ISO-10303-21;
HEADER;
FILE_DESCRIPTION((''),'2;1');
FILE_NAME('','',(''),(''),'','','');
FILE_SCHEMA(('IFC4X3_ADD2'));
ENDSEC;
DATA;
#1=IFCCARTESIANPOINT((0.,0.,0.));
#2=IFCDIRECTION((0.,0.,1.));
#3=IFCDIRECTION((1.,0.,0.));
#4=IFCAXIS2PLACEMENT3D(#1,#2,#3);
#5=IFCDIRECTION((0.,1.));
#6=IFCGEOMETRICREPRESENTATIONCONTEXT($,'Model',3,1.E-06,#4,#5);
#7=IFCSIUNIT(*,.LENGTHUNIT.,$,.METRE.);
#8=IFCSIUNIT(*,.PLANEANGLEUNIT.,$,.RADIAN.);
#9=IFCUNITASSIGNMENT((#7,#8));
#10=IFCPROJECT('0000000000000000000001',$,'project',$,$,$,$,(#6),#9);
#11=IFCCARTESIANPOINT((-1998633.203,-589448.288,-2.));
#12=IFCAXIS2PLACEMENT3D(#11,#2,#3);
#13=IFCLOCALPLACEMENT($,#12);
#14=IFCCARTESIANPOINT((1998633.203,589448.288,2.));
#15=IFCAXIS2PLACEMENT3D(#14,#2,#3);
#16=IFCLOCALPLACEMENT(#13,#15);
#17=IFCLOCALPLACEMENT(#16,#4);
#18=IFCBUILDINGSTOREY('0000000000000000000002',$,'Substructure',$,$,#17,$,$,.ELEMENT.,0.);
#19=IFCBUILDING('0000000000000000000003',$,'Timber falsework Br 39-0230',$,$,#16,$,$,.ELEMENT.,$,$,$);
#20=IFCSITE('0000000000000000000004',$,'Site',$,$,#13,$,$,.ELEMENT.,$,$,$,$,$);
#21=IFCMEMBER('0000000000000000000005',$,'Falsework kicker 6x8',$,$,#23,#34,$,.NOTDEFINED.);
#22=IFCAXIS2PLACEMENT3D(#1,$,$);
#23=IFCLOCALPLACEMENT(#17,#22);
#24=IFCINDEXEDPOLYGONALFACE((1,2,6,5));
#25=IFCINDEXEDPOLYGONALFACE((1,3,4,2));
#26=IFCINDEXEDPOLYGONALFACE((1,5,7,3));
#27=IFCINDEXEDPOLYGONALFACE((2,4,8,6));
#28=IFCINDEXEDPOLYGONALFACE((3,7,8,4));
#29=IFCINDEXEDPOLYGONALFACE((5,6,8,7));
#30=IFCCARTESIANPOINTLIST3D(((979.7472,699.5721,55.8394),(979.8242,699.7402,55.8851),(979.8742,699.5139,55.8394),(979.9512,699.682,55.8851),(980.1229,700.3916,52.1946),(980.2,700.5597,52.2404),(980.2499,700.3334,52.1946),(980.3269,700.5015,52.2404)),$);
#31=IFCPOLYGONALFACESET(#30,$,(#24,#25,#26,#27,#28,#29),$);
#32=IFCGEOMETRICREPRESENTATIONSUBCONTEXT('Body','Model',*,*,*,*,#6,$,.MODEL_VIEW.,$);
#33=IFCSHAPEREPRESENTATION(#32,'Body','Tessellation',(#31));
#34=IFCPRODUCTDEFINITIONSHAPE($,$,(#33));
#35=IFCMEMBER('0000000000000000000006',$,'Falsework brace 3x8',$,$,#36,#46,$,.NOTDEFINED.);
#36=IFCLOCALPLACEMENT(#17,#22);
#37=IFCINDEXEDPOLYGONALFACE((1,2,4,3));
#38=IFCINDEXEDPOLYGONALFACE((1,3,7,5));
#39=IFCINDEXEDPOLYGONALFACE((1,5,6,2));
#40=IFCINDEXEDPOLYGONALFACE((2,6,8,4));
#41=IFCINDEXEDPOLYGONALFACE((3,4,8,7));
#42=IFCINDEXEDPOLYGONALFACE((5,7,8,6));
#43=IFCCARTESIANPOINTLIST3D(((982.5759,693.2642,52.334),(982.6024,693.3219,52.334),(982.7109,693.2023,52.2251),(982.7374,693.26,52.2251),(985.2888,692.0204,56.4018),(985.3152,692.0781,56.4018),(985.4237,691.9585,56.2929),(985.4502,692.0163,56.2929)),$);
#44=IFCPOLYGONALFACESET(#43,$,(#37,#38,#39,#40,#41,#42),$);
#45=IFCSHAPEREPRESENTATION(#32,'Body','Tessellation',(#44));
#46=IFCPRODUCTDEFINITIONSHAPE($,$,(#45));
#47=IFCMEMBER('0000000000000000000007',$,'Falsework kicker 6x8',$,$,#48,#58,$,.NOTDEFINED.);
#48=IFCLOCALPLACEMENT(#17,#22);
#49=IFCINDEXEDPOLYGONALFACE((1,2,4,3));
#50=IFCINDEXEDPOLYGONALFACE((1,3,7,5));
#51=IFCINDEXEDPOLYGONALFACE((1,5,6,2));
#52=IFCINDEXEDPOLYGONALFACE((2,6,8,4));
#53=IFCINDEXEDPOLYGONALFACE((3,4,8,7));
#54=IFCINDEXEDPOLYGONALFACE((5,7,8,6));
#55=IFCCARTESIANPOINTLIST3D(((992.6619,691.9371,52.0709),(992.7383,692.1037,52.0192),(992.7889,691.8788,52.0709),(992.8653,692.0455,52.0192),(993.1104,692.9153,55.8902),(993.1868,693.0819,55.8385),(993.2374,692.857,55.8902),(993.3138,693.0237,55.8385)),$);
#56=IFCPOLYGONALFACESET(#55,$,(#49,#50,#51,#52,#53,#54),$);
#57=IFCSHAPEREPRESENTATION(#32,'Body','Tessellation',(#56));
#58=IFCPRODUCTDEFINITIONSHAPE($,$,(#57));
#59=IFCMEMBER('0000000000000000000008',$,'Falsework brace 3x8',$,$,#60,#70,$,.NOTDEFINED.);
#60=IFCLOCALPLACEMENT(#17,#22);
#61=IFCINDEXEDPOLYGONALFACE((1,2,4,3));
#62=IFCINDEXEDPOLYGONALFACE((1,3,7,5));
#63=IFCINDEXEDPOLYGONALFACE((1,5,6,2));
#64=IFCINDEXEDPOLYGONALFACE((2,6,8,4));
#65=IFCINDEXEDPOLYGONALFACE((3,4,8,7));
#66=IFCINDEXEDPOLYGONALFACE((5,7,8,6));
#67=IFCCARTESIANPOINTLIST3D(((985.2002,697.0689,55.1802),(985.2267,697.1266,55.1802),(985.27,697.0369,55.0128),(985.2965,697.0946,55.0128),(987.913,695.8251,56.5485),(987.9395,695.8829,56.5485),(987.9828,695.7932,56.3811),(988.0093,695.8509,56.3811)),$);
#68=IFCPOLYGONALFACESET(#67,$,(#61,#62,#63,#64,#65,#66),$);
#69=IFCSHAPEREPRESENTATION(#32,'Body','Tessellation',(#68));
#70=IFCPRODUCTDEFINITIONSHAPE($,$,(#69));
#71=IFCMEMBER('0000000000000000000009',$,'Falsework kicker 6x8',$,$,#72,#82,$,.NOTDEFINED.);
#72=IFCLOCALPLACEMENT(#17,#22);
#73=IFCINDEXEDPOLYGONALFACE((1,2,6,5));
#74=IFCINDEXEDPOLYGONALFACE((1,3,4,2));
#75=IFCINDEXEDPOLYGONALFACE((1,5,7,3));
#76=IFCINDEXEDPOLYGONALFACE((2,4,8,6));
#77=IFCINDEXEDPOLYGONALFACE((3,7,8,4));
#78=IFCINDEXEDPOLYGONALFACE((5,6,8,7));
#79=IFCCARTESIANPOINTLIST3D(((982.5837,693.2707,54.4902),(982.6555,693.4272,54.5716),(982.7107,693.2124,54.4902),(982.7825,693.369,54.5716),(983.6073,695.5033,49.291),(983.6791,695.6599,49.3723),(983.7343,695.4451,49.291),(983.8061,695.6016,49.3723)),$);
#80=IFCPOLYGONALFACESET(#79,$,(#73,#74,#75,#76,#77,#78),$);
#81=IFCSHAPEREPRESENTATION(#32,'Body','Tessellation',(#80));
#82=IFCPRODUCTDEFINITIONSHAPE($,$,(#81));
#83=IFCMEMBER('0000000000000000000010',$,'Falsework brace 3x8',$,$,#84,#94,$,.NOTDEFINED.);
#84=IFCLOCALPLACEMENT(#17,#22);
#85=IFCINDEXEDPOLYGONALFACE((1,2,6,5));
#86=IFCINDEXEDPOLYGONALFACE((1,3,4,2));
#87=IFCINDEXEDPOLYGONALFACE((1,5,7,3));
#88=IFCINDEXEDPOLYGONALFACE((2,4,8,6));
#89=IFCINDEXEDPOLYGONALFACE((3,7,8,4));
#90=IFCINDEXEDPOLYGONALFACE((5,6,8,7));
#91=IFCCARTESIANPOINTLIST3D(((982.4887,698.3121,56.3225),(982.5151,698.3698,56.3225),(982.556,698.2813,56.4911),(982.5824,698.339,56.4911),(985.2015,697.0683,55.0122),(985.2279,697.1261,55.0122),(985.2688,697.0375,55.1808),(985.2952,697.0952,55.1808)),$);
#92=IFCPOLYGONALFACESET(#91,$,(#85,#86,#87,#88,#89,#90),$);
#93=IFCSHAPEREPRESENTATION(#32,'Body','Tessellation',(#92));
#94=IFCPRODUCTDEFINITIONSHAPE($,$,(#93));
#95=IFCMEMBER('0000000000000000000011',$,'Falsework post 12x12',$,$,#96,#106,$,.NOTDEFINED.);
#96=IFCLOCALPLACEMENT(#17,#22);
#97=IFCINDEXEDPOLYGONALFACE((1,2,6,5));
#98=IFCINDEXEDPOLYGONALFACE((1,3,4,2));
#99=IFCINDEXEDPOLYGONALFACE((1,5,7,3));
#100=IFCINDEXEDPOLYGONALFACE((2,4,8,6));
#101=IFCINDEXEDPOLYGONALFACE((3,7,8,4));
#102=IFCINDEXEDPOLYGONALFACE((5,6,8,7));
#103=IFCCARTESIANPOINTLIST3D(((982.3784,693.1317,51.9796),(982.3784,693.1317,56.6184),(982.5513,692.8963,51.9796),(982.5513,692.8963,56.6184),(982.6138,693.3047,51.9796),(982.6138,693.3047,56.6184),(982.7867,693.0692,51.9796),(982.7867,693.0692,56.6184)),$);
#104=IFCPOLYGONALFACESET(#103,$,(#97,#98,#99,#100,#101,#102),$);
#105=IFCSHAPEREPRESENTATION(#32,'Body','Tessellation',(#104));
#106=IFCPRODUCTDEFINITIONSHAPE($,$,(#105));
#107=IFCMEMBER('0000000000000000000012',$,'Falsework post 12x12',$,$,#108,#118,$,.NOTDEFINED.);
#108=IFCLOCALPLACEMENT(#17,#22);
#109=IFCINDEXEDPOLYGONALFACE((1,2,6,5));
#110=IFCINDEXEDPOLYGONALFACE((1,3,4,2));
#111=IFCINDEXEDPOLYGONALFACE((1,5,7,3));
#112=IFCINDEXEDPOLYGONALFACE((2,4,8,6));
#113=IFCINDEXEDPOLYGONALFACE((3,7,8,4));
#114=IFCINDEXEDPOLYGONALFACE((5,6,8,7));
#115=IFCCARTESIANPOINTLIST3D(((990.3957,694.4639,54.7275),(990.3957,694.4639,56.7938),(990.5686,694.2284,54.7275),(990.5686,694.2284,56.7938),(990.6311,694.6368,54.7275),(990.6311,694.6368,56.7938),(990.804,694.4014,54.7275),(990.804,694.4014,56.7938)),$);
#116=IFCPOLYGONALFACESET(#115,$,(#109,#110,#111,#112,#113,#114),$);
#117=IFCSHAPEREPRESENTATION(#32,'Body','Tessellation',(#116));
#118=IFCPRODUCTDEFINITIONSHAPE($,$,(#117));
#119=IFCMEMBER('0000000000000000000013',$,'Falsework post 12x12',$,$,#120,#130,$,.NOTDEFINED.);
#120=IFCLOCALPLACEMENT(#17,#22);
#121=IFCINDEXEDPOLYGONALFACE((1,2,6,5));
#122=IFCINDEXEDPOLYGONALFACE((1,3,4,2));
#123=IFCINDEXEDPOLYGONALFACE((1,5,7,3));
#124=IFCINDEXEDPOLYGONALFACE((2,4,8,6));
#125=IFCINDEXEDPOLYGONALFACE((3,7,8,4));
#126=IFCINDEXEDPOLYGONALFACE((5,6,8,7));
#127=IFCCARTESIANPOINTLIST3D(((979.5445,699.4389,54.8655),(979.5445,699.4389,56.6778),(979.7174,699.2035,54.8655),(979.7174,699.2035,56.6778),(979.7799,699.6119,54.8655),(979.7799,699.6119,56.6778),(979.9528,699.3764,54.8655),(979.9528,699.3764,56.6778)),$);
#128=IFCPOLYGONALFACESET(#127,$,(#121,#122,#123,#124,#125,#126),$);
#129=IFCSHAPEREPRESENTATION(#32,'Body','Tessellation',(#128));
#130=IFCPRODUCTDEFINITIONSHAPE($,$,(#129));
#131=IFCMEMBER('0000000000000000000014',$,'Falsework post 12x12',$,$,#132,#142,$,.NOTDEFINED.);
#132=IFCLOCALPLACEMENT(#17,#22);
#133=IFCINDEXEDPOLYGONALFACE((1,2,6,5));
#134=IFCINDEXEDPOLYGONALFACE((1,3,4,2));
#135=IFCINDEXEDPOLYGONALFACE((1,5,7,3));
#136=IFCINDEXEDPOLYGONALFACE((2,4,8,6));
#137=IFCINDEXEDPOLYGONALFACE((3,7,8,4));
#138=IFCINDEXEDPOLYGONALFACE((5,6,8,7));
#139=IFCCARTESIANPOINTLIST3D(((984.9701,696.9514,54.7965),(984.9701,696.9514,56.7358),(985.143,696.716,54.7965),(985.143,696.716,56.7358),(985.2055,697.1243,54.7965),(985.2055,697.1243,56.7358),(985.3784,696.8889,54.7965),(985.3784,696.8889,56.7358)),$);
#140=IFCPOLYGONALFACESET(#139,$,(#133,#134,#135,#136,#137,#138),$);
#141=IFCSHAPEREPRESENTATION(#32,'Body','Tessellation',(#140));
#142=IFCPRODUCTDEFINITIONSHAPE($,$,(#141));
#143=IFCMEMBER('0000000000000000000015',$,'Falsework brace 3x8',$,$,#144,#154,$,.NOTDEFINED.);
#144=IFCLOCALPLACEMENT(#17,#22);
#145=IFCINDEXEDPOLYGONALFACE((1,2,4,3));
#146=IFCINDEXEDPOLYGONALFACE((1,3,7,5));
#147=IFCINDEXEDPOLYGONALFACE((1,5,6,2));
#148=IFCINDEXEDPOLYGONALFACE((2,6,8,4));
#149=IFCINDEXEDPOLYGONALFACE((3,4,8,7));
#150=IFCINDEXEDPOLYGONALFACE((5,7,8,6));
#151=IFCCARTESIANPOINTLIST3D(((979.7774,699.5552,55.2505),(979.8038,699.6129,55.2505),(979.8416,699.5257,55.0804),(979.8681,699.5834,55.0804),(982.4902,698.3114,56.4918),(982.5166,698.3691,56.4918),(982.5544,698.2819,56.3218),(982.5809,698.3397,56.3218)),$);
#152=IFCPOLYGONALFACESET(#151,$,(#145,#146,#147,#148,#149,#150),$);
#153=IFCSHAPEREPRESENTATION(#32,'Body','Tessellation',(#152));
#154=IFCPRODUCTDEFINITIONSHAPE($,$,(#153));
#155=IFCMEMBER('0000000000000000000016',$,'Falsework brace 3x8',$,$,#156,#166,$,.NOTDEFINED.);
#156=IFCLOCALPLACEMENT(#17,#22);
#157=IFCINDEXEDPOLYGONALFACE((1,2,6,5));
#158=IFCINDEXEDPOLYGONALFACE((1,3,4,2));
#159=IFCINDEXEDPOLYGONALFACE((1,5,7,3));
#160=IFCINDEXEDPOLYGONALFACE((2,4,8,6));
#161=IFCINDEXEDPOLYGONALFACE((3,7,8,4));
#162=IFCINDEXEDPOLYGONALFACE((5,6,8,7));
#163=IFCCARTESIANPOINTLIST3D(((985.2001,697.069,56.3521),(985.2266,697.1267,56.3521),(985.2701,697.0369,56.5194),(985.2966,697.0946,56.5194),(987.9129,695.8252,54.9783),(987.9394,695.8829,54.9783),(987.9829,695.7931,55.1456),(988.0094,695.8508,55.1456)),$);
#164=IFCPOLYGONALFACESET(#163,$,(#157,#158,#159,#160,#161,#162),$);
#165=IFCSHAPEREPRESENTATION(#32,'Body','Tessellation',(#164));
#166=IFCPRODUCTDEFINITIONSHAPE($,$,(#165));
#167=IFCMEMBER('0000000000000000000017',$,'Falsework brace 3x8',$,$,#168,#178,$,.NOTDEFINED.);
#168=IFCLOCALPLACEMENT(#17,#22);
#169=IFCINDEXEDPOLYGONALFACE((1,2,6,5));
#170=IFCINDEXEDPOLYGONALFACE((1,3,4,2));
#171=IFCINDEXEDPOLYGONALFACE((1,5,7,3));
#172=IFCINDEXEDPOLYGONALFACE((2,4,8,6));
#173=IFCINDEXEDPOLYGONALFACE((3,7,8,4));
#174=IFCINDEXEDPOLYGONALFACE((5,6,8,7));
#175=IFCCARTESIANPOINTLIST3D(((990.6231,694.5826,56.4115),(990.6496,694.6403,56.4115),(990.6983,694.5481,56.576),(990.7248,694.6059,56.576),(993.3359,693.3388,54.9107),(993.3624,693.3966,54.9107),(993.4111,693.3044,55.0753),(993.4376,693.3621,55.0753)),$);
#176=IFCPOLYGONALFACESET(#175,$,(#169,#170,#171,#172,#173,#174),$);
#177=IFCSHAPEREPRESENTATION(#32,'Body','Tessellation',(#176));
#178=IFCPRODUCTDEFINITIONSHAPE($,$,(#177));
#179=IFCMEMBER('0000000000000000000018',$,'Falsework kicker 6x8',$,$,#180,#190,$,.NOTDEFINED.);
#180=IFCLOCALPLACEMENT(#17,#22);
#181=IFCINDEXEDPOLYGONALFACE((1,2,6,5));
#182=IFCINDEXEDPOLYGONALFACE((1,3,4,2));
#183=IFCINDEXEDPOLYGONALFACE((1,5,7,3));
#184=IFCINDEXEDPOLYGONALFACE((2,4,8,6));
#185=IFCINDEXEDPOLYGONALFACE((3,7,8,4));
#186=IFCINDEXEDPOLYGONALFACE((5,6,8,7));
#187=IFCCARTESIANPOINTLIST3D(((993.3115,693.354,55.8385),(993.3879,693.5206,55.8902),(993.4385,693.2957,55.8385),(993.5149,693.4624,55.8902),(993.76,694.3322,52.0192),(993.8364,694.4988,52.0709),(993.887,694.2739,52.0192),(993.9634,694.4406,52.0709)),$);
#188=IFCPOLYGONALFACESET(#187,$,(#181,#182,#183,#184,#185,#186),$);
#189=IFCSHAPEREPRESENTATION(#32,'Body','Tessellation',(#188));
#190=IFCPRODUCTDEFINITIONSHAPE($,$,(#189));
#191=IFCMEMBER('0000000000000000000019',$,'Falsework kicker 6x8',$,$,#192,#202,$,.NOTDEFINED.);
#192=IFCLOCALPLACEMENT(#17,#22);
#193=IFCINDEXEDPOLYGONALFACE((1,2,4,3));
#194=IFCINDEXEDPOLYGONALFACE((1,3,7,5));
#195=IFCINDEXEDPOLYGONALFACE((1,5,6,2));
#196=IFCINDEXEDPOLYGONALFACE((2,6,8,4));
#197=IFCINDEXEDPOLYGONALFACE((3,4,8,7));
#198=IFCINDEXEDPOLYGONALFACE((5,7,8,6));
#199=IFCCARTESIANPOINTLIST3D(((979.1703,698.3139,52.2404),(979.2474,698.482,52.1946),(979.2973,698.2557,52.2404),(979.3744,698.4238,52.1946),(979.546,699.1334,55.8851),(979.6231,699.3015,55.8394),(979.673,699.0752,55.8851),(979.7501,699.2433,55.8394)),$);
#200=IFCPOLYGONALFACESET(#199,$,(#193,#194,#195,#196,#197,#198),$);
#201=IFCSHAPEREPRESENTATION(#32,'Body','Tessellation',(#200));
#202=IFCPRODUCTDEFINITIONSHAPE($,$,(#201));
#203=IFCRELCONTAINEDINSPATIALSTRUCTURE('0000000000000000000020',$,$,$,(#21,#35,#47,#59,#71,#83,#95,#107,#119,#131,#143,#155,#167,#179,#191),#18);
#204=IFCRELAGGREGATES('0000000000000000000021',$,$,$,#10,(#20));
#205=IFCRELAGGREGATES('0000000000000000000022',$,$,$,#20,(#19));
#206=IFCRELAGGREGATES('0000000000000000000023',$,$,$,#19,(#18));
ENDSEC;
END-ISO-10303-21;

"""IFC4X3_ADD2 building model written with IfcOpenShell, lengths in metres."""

from ifc_helpers import new_model, si_unit, direction, frame, origin, origin_with_axes, origin_2d, place, context, subcontext, project, spatial, rectangle, extrude, element, save


model = new_model("IFC4X3_ADD2")

# Units and contexts
model_context = context("Model", 3, precision=1e-06, world=origin_with_axes(), true_north=direction((0.0, 1.0)))
body_context = subcontext(model_context, "Body", "Model", "MODEL_VIEW")
ifc_project = project(units=[si_unit("LENGTHUNIT", "METRE"), si_unit("PLANEANGLEUNIT", "RADIAN")], contexts=[model_context])

# Site, building, storey
site_placement = place(None, frame((-1998633.203, -589448.288, -2.0), z_axis=(0.0, 0.0, 1.0), x_axis=(1.0, 0.0, 0.0)))
site = spatial("IfcSite", under=ifc_project, at=site_placement, Name="Site", CompositionType="ELEMENT")
building_placement = place(site_placement, frame((1998633.203, 589448.288, 2.0), z_axis=(0.0, 0.0, 1.0), x_axis=(1.0, 0.0, 0.0)))
building = spatial("IfcBuilding", under=site, at=building_placement, Name="Timber falsework Br 39-0230", CompositionType="ELEMENT")
storey_placement = place(building_placement, origin_with_axes())
storey = spatial("IfcBuildingStorey", under=building, at=storey_placement, Name="Substructure", CompositionType="ELEMENT", Elevation=0.0)

# Members
member_1_placement = place(storey_placement, frame((979.8492, 699.627, 55.8622), z_axis=(0.100071, 0.218267, -0.970745), x_axis=(-0.909014, 0.416765, 0.0)))
element("IfcMember", 1, at=member_1_placement, inside=storey, Name="Falsework kicker 6x8", PredefinedType="NOTDEFINED", context=body_context, shape_type="SweptSolid", body=[
    extrude(rectangle(XDim=0.1397, YDim=0.1905, at=origin_2d()), origin(), (0.0, 0.0, 1.0), 3.7546),
])
member_2_placement = place(storey_placement, frame((982.6567, 693.2621, 52.2796), z_axis=(0.537709, -0.246529, 0.806283), x_axis=(0.416765, 0.909014, 0.0)))
element("IfcMember", 2, at=member_2_placement, inside=storey, Name="Falsework brace 3x8", PredefinedType="NOTDEFINED", context=body_context, shape_type="SweptSolid", body=[
    extrude(rectangle(XDim=0.0635, YDim=0.1841, at=origin_2d()), origin(), (0.0, 0.0, 1.0), 5.0451),
])
member_3_placement = place(storey_placement, frame((993.2121, 692.9695, 55.8644), z_axis=(-0.113026, -0.246523, -0.962524), x_axis=(0.909014, -0.416765, 0.0)))
element("IfcMember", 3, at=member_3_placement, inside=storey, Name="Falsework kicker 6x8", PredefinedType="NOTDEFINED", context=body_context, shape_type="SweptSolid", body=[
    extrude(rectangle(XDim=0.1397, YDim=0.1905, at=origin_2d()), origin(), (0.0, 0.0, 1.0), 3.968),
])
member_4_placement = place(storey_placement, frame((985.2483, 697.0818, 55.0965), z_axis=(0.826304, -0.378844, 0.416772), x_axis=(0.416765, 0.909014, 0.0)))
element("IfcMember", 4, at=member_4_placement, inside=storey, Name="Falsework brace 3x8", PredefinedType="NOTDEFINED", context=body_context, shape_type="SweptSolid", body=[
    extrude(rectangle(XDim=0.0635, YDim=0.1841, at=origin_2d()), origin(), (0.0, 0.0, 1.0), 3.2831),
])
member_5_placement = place(storey_placement, frame((982.6831, 693.3198, 54.5309), z_axis=(0.178013, 0.388267, -0.90419), x_axis=(-0.909014, 0.416765, 0.0)))
element("IfcMember", 5, at=member_5_placement, inside=storey, Name="Falsework kicker 6x8", PredefinedType="NOTDEFINED", context=body_context, shape_type="SweptSolid", body=[
    extrude(rectangle(XDim=0.1397, YDim=0.1905, at=origin_2d()), origin(), (0.0, 0.0, 1.0), 5.7502),
])
member_6_placement = place(storey_placement, frame((982.5355, 698.3255, 56.4068), z_axis=(0.832324, -0.381604, -0.402013), x_axis=(0.416765, 0.909014, 0.0)))
element("IfcMember", 6, at=member_6_placement, inside=storey, Name="Falsework brace 3x8", PredefinedType="NOTDEFINED", context=body_context, shape_type="SweptSolid", body=[
    extrude(rectangle(XDim=0.0635, YDim=0.1841, at=origin_2d()), origin(), (0.0, 0.0, 1.0), 3.2593),
])
member_7_placement = place(storey_placement, frame((982.5826, 693.1005, 51.9796), z_axis=(0.0, 0.0, 1.0), x_axis=(-0.805928, -0.592013, 0.0)))
element("IfcMember", 7, at=member_7_placement, inside=storey, Name="Falsework post 12x12", PredefinedType="NOTDEFINED", context=body_context, shape_type="SweptSolid", body=[
    extrude(rectangle(XDim=0.2921, YDim=0.2921, at=origin_2d()), origin(), (0.0, 0.0, 1.0), 4.6388),
])
member_8_placement = place(storey_placement, frame((990.5999, 694.4326, 54.7275), z_axis=(0.0, 0.0, 1.0), x_axis=(-0.805928, -0.592013, 0.0)))
element("IfcMember", 8, at=member_8_placement, inside=storey, Name="Falsework post 12x12", PredefinedType="NOTDEFINED", context=body_context, shape_type="SweptSolid", body=[
    extrude(rectangle(XDim=0.2921, YDim=0.2921, at=origin_2d()), origin(), (0.0, 0.0, 1.0), 2.0663),
])
member_9_placement = place(storey_placement, frame((979.7486, 699.4077, 54.8655), z_axis=(0.0, 0.0, 1.0), x_axis=(-0.805928, -0.592013, 0.0)))
element("IfcMember", 9, at=member_9_placement, inside=storey, Name="Falsework post 12x12", PredefinedType="NOTDEFINED", context=body_context, shape_type="SweptSolid", body=[
    extrude(rectangle(XDim=0.2921, YDim=0.2921, at=origin_2d()), origin(), (0.0, 0.0, 1.0), 1.8123),
])
member_10_placement = place(storey_placement, frame((985.1742, 696.9202, 54.7965), z_axis=(0.0, 0.0, 1.0), x_axis=(-0.805928, -0.592013, 0.0)))
element("IfcMember", 10, at=member_10_placement, inside=storey, Name="Falsework post 12x12", PredefinedType="NOTDEFINED", context=body_context, shape_type="SweptSolid", body=[
    extrude(rectangle(XDim=0.2921, YDim=0.2921, at=origin_2d()), origin(), (0.0, 0.0, 1.0), 1.9393),
])
member_11_placement = place(storey_placement, frame((979.8227, 699.5693, 55.1655), z_axis=(0.839306, -0.384806, 0.384044), x_axis=(0.416765, 0.909014, 0.0)))
element("IfcMember", 11, at=member_11_placement, inside=storey, Name="Falsework brace 3x8", PredefinedType="NOTDEFINED", context=body_context, shape_type="SweptSolid", body=[
    extrude(rectangle(XDim=0.0635, YDim=0.1841, at=origin_2d()), origin(), (0.0, 0.0, 1.0), 3.2322),
])
member_12_placement = place(storey_placement, frame((985.2483, 697.0818, 56.4358), z_axis=(0.825727, -0.37858, -0.418153), x_axis=(0.416765, 0.909014, 0.0)))
element("IfcMember", 12, at=member_12_placement, inside=storey, Name="Falsework brace 3x8", PredefinedType="NOTDEFINED", context=body_context, shape_type="SweptSolid", body=[
    extrude(rectangle(XDim=0.0635, YDim=0.1841, at=origin_2d()), origin(), (0.0, 0.0, 1.0), 3.2854),
])
member_13_placement = place(storey_placement, frame((990.674, 694.5942, 56.4938), z_axis=(0.81211, -0.372336, -0.44927), x_axis=(0.416765, 0.909014, 0.0)))
element("IfcMember", 13, at=member_13_placement, inside=storey, Name="Falsework brace 3x8", PredefinedType="NOTDEFINED", context=body_context, shape_type="SweptSolid", body=[
    extrude(rectangle(XDim=0.0635, YDim=0.1841, at=origin_2d()), origin(), (0.0, 0.0, 1.0), 3.3404),
])
member_14_placement = place(storey_placement, frame((993.4132, 693.4082, 55.8644), z_axis=(0.113026, 0.246523, -0.962524), x_axis=(-0.909014, 0.416765, 0.0)))
element("IfcMember", 14, at=member_14_placement, inside=storey, Name="Falsework kicker 6x8", PredefinedType="NOTDEFINED", context=body_context, shape_type="SweptSolid", body=[
    extrude(rectangle(XDim=0.1397, YDim=0.1905, at=origin_2d()), origin(), (0.0, 0.0, 1.0), 3.968),
])
member_15_placement = place(storey_placement, frame((979.6481, 699.1883, 55.8622), z_axis=(-0.100071, -0.218267, -0.970745), x_axis=(0.909014, -0.416765, 0.0)))
element("IfcMember", 15, at=member_15_placement, inside=storey, Name="Falsework kicker 6x8", PredefinedType="NOTDEFINED", context=body_context, shape_type="SweptSolid", body=[
    extrude(rectangle(XDim=0.1397, YDim=0.1905, at=origin_2d()), origin(), (0.0, 0.0, 1.0), 3.7546),
])

save(model, "model.ifc")
